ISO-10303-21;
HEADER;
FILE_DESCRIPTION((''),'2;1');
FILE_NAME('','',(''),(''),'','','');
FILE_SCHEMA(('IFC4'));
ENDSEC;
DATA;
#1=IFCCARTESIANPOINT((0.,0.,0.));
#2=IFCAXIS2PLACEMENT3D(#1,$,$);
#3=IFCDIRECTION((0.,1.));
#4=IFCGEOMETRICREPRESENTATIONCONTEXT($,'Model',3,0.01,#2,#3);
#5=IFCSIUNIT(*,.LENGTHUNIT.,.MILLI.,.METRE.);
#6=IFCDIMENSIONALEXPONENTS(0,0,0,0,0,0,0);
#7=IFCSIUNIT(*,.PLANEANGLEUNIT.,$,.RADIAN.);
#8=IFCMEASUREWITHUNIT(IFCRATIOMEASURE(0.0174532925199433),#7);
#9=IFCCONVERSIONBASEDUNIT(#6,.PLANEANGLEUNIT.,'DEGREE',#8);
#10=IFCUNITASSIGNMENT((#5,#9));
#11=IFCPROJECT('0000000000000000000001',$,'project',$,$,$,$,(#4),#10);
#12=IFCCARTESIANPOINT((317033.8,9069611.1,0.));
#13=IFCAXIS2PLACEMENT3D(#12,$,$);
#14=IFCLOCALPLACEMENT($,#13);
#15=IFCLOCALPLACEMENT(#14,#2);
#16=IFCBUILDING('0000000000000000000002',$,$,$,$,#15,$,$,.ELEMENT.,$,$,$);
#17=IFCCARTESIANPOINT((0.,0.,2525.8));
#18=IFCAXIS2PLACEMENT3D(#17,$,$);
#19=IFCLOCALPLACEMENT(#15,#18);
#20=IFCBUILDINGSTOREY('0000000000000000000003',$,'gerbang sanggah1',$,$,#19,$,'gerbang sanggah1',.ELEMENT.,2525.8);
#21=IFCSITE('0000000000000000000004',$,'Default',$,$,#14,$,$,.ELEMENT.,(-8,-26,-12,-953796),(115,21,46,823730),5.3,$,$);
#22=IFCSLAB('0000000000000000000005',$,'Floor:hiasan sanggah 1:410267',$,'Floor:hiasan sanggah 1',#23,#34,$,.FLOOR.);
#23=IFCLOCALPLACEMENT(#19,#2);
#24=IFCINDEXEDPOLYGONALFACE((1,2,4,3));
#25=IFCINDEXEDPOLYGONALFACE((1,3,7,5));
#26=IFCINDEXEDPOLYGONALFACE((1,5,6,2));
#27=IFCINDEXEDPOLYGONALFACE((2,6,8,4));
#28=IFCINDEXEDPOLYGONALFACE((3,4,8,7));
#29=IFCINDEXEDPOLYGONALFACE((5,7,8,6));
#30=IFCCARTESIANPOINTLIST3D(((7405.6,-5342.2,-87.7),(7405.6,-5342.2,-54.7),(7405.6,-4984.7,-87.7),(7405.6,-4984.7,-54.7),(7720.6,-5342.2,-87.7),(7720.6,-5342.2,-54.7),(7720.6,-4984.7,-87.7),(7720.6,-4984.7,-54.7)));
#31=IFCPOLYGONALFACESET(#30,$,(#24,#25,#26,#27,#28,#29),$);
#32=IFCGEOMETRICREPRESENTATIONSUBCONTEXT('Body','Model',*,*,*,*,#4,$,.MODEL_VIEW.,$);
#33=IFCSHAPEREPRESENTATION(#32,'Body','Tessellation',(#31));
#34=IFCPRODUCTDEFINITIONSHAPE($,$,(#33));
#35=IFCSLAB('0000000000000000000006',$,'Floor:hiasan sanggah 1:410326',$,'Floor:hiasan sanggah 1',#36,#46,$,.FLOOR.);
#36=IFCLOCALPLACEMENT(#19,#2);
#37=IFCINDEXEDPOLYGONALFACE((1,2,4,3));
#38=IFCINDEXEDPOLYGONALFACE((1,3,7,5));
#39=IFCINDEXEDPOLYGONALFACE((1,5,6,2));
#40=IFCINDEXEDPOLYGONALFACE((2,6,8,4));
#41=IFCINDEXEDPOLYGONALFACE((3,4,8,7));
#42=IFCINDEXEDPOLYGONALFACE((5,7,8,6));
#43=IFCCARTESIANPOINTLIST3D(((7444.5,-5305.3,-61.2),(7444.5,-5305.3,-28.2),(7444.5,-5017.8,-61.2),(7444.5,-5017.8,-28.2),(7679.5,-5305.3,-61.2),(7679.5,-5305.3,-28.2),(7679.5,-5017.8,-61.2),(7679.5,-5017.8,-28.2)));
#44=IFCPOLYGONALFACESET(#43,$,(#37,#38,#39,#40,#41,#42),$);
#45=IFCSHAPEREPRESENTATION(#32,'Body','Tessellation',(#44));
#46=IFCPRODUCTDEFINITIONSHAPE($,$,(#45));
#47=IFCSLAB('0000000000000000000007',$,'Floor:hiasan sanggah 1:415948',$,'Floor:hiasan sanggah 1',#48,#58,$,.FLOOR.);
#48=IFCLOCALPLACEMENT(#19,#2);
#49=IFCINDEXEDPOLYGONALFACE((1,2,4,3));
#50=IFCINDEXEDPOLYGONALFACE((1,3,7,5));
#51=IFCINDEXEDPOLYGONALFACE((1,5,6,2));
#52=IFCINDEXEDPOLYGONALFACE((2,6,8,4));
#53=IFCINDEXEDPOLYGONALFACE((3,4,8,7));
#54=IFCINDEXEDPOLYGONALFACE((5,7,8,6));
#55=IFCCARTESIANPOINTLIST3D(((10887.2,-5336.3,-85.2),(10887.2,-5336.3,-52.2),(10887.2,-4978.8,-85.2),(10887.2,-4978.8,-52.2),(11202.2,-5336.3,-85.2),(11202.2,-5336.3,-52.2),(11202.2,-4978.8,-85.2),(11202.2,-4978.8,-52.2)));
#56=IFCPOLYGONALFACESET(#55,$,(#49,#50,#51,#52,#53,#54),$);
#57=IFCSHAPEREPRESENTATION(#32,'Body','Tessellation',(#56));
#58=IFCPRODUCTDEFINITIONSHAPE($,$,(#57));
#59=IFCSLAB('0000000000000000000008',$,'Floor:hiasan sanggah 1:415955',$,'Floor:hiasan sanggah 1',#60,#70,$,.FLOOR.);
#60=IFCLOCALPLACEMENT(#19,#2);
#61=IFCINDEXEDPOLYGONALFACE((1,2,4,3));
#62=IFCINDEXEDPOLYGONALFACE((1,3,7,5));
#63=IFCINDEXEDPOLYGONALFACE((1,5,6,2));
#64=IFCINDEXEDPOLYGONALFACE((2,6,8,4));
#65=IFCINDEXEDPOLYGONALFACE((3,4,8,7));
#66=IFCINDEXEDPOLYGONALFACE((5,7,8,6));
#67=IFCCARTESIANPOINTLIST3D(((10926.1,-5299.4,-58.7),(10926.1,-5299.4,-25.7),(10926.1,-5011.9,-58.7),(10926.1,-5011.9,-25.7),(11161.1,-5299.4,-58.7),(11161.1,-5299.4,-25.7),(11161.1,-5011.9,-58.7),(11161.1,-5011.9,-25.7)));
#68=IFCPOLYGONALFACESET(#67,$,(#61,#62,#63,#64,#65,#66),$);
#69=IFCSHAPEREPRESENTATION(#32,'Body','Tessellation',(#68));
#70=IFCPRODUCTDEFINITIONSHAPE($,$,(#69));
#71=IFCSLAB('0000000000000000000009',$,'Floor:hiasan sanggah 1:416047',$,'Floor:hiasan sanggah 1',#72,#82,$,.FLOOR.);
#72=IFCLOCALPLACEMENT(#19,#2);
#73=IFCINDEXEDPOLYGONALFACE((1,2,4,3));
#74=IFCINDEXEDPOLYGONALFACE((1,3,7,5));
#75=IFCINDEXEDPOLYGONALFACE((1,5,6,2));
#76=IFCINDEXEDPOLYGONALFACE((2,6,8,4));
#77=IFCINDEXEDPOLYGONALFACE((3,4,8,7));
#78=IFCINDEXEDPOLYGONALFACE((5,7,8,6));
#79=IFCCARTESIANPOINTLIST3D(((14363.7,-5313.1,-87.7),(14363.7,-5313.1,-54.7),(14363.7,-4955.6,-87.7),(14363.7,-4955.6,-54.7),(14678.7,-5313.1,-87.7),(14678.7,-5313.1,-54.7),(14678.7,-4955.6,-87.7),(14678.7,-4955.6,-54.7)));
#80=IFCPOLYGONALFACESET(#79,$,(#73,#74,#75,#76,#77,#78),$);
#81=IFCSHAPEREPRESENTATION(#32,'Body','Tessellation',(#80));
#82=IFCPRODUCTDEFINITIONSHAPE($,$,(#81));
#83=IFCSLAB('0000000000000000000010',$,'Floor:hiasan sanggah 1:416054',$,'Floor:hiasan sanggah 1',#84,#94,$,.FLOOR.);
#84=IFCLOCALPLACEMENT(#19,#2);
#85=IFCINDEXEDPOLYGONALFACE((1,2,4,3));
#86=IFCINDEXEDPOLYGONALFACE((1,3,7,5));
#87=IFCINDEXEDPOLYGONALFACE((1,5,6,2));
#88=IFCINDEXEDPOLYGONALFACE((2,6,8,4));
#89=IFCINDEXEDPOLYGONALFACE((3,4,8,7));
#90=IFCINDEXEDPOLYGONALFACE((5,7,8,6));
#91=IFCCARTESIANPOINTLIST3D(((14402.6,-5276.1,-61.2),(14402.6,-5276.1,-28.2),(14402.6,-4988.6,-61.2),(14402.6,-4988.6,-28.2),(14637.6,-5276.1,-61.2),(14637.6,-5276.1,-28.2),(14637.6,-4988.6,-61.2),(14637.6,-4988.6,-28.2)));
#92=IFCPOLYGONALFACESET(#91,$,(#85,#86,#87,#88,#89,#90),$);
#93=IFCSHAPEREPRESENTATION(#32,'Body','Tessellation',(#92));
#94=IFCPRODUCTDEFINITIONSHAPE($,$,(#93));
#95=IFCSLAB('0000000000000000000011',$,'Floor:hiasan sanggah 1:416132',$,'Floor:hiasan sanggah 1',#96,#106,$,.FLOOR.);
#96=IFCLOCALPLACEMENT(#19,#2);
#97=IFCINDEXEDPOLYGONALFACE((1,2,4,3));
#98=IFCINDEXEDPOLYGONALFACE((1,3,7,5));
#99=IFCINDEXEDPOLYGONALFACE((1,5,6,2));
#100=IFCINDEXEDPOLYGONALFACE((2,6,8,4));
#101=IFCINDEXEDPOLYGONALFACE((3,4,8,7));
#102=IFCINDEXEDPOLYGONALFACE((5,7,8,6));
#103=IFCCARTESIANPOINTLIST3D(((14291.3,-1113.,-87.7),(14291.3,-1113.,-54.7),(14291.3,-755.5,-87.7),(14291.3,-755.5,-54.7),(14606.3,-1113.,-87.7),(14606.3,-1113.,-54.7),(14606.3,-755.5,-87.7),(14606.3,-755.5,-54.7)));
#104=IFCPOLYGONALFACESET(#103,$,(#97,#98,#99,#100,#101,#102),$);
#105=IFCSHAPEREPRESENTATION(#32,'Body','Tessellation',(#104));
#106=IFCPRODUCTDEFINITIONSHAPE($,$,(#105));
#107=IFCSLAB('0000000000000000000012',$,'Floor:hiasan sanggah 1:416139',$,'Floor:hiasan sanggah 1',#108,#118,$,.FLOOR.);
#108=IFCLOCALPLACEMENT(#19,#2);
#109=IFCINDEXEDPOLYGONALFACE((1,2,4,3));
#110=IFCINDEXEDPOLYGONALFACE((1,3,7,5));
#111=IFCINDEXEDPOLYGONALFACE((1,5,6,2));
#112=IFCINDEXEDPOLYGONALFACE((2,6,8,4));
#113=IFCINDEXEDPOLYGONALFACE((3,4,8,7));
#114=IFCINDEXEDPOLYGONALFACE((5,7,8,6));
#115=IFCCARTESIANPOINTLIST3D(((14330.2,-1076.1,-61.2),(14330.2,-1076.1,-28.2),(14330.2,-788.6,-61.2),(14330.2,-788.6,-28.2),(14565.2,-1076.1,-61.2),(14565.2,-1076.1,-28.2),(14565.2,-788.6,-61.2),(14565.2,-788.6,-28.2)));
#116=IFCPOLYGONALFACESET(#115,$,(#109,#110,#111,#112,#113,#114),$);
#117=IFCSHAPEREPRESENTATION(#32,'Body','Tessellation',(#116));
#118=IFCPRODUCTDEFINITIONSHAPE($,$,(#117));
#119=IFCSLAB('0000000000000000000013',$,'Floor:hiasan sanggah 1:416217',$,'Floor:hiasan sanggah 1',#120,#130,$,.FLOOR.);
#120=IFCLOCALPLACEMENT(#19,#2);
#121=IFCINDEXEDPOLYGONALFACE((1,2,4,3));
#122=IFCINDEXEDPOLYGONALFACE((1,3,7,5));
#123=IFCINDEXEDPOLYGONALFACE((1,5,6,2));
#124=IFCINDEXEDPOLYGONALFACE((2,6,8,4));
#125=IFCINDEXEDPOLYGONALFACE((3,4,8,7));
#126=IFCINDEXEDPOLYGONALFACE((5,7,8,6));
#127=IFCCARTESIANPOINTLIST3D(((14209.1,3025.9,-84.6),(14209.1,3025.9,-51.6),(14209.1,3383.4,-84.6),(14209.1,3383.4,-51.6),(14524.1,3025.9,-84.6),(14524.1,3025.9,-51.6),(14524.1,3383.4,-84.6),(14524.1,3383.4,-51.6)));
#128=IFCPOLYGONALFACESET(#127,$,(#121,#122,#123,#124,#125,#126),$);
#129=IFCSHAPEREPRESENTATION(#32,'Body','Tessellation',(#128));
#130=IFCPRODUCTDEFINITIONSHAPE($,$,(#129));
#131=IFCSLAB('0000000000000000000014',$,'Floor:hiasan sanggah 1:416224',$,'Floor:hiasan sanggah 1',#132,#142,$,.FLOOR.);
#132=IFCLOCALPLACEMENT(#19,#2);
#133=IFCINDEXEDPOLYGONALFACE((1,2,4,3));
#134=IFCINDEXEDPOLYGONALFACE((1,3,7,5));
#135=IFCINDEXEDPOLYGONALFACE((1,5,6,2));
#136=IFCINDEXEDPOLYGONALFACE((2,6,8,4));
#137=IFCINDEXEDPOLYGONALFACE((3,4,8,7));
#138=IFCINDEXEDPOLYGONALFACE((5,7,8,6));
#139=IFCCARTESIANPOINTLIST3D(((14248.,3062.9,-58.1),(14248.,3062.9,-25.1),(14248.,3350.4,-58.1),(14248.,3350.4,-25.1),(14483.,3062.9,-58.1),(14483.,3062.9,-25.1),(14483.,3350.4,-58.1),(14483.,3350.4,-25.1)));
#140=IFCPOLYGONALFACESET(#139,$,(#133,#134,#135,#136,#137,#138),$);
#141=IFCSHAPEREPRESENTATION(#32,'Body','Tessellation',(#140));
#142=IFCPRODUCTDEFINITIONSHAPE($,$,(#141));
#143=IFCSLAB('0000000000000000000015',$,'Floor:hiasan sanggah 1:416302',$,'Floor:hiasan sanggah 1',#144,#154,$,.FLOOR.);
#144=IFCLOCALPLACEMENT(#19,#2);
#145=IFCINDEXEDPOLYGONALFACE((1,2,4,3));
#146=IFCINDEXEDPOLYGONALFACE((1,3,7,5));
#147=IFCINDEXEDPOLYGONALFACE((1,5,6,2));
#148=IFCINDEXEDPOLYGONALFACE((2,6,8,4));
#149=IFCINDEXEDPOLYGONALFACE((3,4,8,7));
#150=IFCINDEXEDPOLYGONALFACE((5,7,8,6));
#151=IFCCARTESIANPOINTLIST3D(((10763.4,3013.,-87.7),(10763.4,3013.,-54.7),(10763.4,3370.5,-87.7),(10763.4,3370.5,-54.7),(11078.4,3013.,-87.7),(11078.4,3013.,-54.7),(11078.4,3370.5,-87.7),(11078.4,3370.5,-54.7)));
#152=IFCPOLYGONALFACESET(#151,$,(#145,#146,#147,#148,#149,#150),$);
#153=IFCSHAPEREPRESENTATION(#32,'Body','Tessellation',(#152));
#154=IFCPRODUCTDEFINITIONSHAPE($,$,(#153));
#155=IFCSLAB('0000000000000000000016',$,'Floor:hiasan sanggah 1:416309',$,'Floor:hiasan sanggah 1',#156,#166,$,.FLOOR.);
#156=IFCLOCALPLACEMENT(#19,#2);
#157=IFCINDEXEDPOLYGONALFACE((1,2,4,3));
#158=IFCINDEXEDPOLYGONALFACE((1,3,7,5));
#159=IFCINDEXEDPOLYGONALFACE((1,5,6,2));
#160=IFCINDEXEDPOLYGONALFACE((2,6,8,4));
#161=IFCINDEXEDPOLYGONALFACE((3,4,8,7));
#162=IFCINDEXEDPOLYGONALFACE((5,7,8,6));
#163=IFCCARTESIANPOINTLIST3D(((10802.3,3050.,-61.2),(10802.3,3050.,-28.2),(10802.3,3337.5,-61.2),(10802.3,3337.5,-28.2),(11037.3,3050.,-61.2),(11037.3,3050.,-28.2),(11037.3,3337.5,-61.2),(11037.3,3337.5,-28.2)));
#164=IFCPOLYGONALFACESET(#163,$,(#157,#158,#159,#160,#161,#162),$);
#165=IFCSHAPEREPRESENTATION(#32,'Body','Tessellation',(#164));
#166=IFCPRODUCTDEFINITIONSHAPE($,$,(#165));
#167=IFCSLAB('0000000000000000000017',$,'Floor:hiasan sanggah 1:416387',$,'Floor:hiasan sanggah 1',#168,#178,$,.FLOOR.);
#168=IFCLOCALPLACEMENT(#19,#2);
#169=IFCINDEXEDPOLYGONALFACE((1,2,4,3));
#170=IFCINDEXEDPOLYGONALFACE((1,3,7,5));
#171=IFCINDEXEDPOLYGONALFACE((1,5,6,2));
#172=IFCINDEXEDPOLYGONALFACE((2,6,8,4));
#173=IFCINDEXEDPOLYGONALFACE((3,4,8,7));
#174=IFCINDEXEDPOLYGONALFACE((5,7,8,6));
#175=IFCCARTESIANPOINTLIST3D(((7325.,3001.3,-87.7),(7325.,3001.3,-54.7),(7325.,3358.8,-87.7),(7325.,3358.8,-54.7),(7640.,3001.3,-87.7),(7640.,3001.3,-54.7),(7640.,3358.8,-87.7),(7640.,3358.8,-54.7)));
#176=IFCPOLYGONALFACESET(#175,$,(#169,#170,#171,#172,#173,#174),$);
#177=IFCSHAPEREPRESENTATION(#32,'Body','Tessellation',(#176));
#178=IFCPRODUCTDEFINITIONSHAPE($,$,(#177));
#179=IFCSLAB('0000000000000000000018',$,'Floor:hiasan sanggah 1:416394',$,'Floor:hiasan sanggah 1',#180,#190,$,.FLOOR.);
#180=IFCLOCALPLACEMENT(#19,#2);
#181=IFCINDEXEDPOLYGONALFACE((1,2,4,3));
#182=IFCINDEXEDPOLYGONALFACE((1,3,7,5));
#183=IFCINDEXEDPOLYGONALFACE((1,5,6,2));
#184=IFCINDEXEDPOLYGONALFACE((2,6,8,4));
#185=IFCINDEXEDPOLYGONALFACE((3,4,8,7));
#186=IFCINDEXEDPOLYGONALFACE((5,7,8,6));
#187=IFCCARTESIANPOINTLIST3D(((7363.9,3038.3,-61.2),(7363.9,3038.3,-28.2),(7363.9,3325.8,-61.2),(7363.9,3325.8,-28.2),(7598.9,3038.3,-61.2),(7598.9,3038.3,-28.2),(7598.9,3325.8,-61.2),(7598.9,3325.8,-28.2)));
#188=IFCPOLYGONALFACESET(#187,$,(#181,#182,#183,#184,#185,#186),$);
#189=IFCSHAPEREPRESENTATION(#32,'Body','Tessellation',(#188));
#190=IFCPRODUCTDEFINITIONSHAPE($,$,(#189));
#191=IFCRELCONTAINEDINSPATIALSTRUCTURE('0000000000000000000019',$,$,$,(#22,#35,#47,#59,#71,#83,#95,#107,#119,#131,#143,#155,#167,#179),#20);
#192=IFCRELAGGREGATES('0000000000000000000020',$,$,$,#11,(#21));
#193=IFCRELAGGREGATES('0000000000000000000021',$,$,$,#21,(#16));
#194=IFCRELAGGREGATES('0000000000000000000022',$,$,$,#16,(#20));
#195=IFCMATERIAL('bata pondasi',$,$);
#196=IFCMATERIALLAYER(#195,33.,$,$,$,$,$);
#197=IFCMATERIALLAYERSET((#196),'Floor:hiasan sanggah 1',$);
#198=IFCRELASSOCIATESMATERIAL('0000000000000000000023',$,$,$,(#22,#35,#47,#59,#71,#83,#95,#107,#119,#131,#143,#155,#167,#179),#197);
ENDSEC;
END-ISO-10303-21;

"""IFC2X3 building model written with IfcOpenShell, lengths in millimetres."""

from ifc_helpers import new_model, entity, si_unit, converted_unit, direction, frame, frame_2d, origin, origin_2d_with_axis, place, context, subcontext, project, spatial, rectangle, extrude, material, layer, layer_set, layer_usage, element, save


model = new_model("IFC2X3")

# Units and contexts
model_context = context("Model", 3, precision=0.01, world=origin(), true_north=direction((0.0, 1.0)))
body_context = subcontext(model_context, "Body", "Model", "MODEL_VIEW")
ifc_project = project(units=[si_unit("LENGTHUNIT", "METRE", prefix="MILLI"), converted_unit("PLANEANGLEUNIT", "DEGREE", entity("IfcRatioMeasure", 0.0174532925199433), si_unit("PLANEANGLEUNIT", "RADIAN"), dimensions=[0, 0, 0, 0, 0, 0, 0])], contexts=[model_context])

# Site, building, storey
site_placement = place(None, frame((317033.8, 9069611.1, 0.0)))
site = spatial("IfcSite", under=ifc_project, at=site_placement, Name="Default", CompositionType="ELEMENT", RefLatitude=(-8, -26, -12, -953796), RefLongitude=(115, 21, 46, 823730), RefElevation=5.3)
building_placement = place(site_placement, origin())
building = spatial("IfcBuilding", under=site, at=building_placement, CompositionType="ELEMENT")
storey_placement = place(building_placement, frame((0.0, 0.0, 2525.8)))
storey = spatial("IfcBuildingStorey", under=building, at=storey_placement, Name="gerbang sanggah1", LongName="gerbang sanggah1", CompositionType="ELEMENT", Elevation=2525.8)

# Slabs
ifc_material = material(Name="bata pondasi")
ifc_layer = layer(ifc_material, 33.0)
ifc_layer_set = layer_set([ifc_layer], Name="Floor:hiasan sanggah 1")
ifc_layer_usage_1 = layer_usage(ifc_layer_set, "AXIS3", "POSITIVE", 0.0)
slab_1_placement = place(storey_placement, origin())
element("IfcSlab", 1, at=slab_1_placement, inside=storey, material=ifc_layer_usage_1, Name="Floor:hiasan sanggah 1:410267", ObjectType="Floor:hiasan sanggah 1", PredefinedType="FLOOR", context=body_context, shape_type="SweptSolid", body=[
    extrude(rectangle(XDim=357.5, YDim=315.0, at=frame_2d((0.0, 0.0), x_axis=(1.0, 0.0))), frame((7563.1, -5163.5, -54.7), z_axis=(0.0, 0.0, -1.0), x_axis=(0.0, 1.0, 0.0)), (0.0, 0.0, 1.0), 33.0),
])
ifc_layer_usage_2 = layer_usage(ifc_layer_set, "AXIS3", "POSITIVE", 0.0)
slab_2_placement = place(storey_placement, origin())
element("IfcSlab", 2, at=slab_2_placement, inside=storey, material=ifc_layer_usage_2, Name="Floor:hiasan sanggah 1:410326", ObjectType="Floor:hiasan sanggah 1", PredefinedType="FLOOR", context=body_context, shape_type="SweptSolid", body=[
    extrude(rectangle(XDim=287.5, YDim=235.0, at=frame_2d((0.0, 0.0), x_axis=(1.0, 0.0))), frame((7562.0, -5161.5, -28.2), z_axis=(0.0, 0.0, -1.0), x_axis=(0.0, 1.0, 0.0)), (0.0, 0.0, 1.0), 33.0),
])
ifc_layer_usage_3 = layer_usage(ifc_layer_set, "AXIS3", "POSITIVE", 0.0)
slab_3_placement = place(storey_placement, origin())
element("IfcSlab", 3, at=slab_3_placement, inside=storey, material=ifc_layer_usage_3, Name="Floor:hiasan sanggah 1:415948", ObjectType="Floor:hiasan sanggah 1", PredefinedType="FLOOR", context=body_context, shape_type="SweptSolid", body=[
    extrude(rectangle(XDim=357.5, YDim=315.0, at=frame_2d((0.0, 0.0), x_axis=(1.0, 0.0))), frame((11044.7, -5157.6, -52.2), z_axis=(0.0, 0.0, -1.0), x_axis=(0.0, 1.0, 0.0)), (0.0, 0.0, 1.0), 33.0),
])
ifc_layer_usage_4 = layer_usage(ifc_layer_set, "AXIS3", "POSITIVE", 0.0)
slab_4_placement = place(storey_placement, origin())
element("IfcSlab", 4, at=slab_4_placement, inside=storey, material=ifc_layer_usage_4, Name="Floor:hiasan sanggah 1:415955", ObjectType="Floor:hiasan sanggah 1", PredefinedType="FLOOR", context=body_context, shape_type="SweptSolid", body=[
    extrude(rectangle(XDim=287.5, YDim=235.0, at=frame_2d((0.0, 0.0), x_axis=(1.0, 0.0))), frame((11043.6, -5155.6, -25.7), z_axis=(0.0, 0.0, -1.0), x_axis=(0.0, 1.0, 0.0)), (0.0, 0.0, 1.0), 33.0),
])
ifc_layer_usage_5 = layer_usage(ifc_layer_set, "AXIS3", "POSITIVE", 0.0)
slab_5_placement = place(storey_placement, origin())
element("IfcSlab", 5, at=slab_5_placement, inside=storey, material=ifc_layer_usage_5, Name="Floor:hiasan sanggah 1:416047", ObjectType="Floor:hiasan sanggah 1", PredefinedType="FLOOR", context=body_context, shape_type="SweptSolid", body=[
    extrude(rectangle(XDim=357.5, YDim=315.0, at=frame_2d((0.0, 0.0), x_axis=(1.0, 0.0))), frame((14521.2, -5134.4, -54.7), z_axis=(0.0, 0.0, -1.0), x_axis=(0.0, 1.0, 0.0)), (0.0, 0.0, 1.0), 33.0),
])
ifc_layer_usage_6 = layer_usage(ifc_layer_set, "AXIS3", "POSITIVE", 0.0)
slab_6_placement = place(storey_placement, origin())
element("IfcSlab", 6, at=slab_6_placement, inside=storey, material=ifc_layer_usage_6, Name="Floor:hiasan sanggah 1:416054", ObjectType="Floor:hiasan sanggah 1", PredefinedType="FLOOR", context=body_context, shape_type="SweptSolid", body=[
    extrude(rectangle(XDim=287.5, YDim=235.0, at=frame_2d((0.0, 0.0), x_axis=(1.0, 0.0))), frame((14520.1, -5132.4, -28.2), z_axis=(0.0, 0.0, -1.0), x_axis=(0.0, 1.0, 0.0)), (0.0, 0.0, 1.0), 33.0),
])
ifc_layer_usage_7 = layer_usage(ifc_layer_set, "AXIS3", "POSITIVE", 0.0)
slab_7_placement = place(storey_placement, origin())
element("IfcSlab", 7, at=slab_7_placement, inside=storey, material=ifc_layer_usage_7, Name="Floor:hiasan sanggah 1:416132", ObjectType="Floor:hiasan sanggah 1", PredefinedType="FLOOR", context=body_context, shape_type="SweptSolid", body=[
    extrude(rectangle(XDim=357.5, YDim=315.0, at=origin_2d_with_axis()), frame((14448.8, -934.3, -54.7), z_axis=(0.0, 0.0, -1.0), x_axis=(0.0, 1.0, 0.0)), (0.0, 0.0, 1.0), 33.0),
])
ifc_layer_usage_8 = layer_usage(ifc_layer_set, "AXIS3", "POSITIVE", 0.0)
slab_8_placement = place(storey_placement, origin())
element("IfcSlab", 8, at=slab_8_placement, inside=storey, material=ifc_layer_usage_8, Name="Floor:hiasan sanggah 1:416139", ObjectType="Floor:hiasan sanggah 1", PredefinedType="FLOOR", context=body_context, shape_type="SweptSolid", body=[
    extrude(rectangle(XDim=287.5, YDim=235.0, at=frame_2d((0.0, 0.0), x_axis=(1.0, 0.0))), frame((14447.7, -932.3, -28.2), z_axis=(0.0, 0.0, -1.0), x_axis=(0.0, 1.0, 0.0)), (0.0, 0.0, 1.0), 33.0),
])
ifc_layer_usage_9 = layer_usage(ifc_layer_set, "AXIS3", "POSITIVE", 0.0)
slab_9_placement = place(storey_placement, origin())
element("IfcSlab", 9, at=slab_9_placement, inside=storey, material=ifc_layer_usage_9, Name="Floor:hiasan sanggah 1:416217", ObjectType="Floor:hiasan sanggah 1", PredefinedType="FLOOR", context=body_context, shape_type="SweptSolid", body=[
    extrude(rectangle(XDim=357.5, YDim=315.0, at=origin_2d_with_axis()), frame((14366.6, 3204.6, -51.6), z_axis=(0.0, 0.0, -1.0), x_axis=(0.0, 1.0, 0.0)), (0.0, 0.0, 1.0), 33.0),
])
ifc_layer_usage_10 = layer_usage(ifc_layer_set, "AXIS3", "POSITIVE", 0.0)
slab_10_placement = place(storey_placement, origin())
element("IfcSlab", 10, at=slab_10_placement, inside=storey, material=ifc_layer_usage_10, Name="Floor:hiasan sanggah 1:416224", ObjectType="Floor:hiasan sanggah 1", PredefinedType="FLOOR", context=body_context, shape_type="SweptSolid", body=[
    extrude(rectangle(XDim=287.5, YDim=235.0, at=origin_2d_with_axis()), frame((14365.5, 3206.6, -25.1), z_axis=(0.0, 0.0, -1.0), x_axis=(0.0, 1.0, 0.0)), (0.0, 0.0, 1.0), 33.0),
])
ifc_layer_usage_11 = layer_usage(ifc_layer_set, "AXIS3", "POSITIVE", 0.0)
slab_11_placement = place(storey_placement, origin())
element("IfcSlab", 11, at=slab_11_placement, inside=storey, material=ifc_layer_usage_11, Name="Floor:hiasan sanggah 1:416302", ObjectType="Floor:hiasan sanggah 1", PredefinedType="FLOOR", context=body_context, shape_type="SweptSolid", body=[
    extrude(rectangle(XDim=357.5, YDim=315.0, at=frame_2d((0.0, 0.0), x_axis=(1.0, 0.0))), frame((10920.9, 3191.8, -54.7), z_axis=(0.0, 0.0, -1.0), x_axis=(0.0, 1.0, 0.0)), (0.0, 0.0, 1.0), 33.0),
])
ifc_layer_usage_12 = layer_usage(ifc_layer_set, "AXIS3", "POSITIVE", 0.0)
slab_12_placement = place(storey_placement, origin())
element("IfcSlab", 12, at=slab_12_placement, inside=storey, material=ifc_layer_usage_12, Name="Floor:hiasan sanggah 1:416309", ObjectType="Floor:hiasan sanggah 1", PredefinedType="FLOOR", context=body_context, shape_type="SweptSolid", body=[
    extrude(rectangle(XDim=287.5, YDim=235.0, at=origin_2d_with_axis()), frame((10919.8, 3193.7, -28.2), z_axis=(0.0, 0.0, -1.0), x_axis=(0.0, 1.0, 0.0)), (0.0, 0.0, 1.0), 33.0),
])
ifc_layer_usage_13 = layer_usage(ifc_layer_set, "AXIS3", "POSITIVE", 0.0)
slab_13_placement = place(storey_placement, origin())
element("IfcSlab", 13, at=slab_13_placement, inside=storey, material=ifc_layer_usage_13, Name="Floor:hiasan sanggah 1:416387", ObjectType="Floor:hiasan sanggah 1", PredefinedType="FLOOR", context=body_context, shape_type="SweptSolid", body=[
    extrude(rectangle(XDim=357.5, YDim=315.0, at=frame_2d((0.0, 0.0), x_axis=(1.0, 0.0))), frame((7482.5, 3180.0, -54.7), z_axis=(0.0, 0.0, -1.0), x_axis=(0.0, 1.0, 0.0)), (0.0, 0.0, 1.0), 33.0),
])
ifc_layer_usage_14 = layer_usage(ifc_layer_set, "AXIS3", "POSITIVE", 0.0)
slab_14_placement = place(storey_placement, origin())
element("IfcSlab", 14, at=slab_14_placement, inside=storey, material=ifc_layer_usage_14, Name="Floor:hiasan sanggah 1:416394", ObjectType="Floor:hiasan sanggah 1", PredefinedType="FLOOR", context=body_context, shape_type="SweptSolid", body=[
    extrude(rectangle(XDim=287.5, YDim=235.0, at=frame_2d((0.0, 0.0), x_axis=(1.0, 0.0))), frame((7481.4, 3182.0, -28.2), z_axis=(0.0, 0.0, -1.0), x_axis=(0.0, 1.0, 0.0)), (0.0, 0.0, 1.0), 33.0),
])

save(model, "model.ifc")
